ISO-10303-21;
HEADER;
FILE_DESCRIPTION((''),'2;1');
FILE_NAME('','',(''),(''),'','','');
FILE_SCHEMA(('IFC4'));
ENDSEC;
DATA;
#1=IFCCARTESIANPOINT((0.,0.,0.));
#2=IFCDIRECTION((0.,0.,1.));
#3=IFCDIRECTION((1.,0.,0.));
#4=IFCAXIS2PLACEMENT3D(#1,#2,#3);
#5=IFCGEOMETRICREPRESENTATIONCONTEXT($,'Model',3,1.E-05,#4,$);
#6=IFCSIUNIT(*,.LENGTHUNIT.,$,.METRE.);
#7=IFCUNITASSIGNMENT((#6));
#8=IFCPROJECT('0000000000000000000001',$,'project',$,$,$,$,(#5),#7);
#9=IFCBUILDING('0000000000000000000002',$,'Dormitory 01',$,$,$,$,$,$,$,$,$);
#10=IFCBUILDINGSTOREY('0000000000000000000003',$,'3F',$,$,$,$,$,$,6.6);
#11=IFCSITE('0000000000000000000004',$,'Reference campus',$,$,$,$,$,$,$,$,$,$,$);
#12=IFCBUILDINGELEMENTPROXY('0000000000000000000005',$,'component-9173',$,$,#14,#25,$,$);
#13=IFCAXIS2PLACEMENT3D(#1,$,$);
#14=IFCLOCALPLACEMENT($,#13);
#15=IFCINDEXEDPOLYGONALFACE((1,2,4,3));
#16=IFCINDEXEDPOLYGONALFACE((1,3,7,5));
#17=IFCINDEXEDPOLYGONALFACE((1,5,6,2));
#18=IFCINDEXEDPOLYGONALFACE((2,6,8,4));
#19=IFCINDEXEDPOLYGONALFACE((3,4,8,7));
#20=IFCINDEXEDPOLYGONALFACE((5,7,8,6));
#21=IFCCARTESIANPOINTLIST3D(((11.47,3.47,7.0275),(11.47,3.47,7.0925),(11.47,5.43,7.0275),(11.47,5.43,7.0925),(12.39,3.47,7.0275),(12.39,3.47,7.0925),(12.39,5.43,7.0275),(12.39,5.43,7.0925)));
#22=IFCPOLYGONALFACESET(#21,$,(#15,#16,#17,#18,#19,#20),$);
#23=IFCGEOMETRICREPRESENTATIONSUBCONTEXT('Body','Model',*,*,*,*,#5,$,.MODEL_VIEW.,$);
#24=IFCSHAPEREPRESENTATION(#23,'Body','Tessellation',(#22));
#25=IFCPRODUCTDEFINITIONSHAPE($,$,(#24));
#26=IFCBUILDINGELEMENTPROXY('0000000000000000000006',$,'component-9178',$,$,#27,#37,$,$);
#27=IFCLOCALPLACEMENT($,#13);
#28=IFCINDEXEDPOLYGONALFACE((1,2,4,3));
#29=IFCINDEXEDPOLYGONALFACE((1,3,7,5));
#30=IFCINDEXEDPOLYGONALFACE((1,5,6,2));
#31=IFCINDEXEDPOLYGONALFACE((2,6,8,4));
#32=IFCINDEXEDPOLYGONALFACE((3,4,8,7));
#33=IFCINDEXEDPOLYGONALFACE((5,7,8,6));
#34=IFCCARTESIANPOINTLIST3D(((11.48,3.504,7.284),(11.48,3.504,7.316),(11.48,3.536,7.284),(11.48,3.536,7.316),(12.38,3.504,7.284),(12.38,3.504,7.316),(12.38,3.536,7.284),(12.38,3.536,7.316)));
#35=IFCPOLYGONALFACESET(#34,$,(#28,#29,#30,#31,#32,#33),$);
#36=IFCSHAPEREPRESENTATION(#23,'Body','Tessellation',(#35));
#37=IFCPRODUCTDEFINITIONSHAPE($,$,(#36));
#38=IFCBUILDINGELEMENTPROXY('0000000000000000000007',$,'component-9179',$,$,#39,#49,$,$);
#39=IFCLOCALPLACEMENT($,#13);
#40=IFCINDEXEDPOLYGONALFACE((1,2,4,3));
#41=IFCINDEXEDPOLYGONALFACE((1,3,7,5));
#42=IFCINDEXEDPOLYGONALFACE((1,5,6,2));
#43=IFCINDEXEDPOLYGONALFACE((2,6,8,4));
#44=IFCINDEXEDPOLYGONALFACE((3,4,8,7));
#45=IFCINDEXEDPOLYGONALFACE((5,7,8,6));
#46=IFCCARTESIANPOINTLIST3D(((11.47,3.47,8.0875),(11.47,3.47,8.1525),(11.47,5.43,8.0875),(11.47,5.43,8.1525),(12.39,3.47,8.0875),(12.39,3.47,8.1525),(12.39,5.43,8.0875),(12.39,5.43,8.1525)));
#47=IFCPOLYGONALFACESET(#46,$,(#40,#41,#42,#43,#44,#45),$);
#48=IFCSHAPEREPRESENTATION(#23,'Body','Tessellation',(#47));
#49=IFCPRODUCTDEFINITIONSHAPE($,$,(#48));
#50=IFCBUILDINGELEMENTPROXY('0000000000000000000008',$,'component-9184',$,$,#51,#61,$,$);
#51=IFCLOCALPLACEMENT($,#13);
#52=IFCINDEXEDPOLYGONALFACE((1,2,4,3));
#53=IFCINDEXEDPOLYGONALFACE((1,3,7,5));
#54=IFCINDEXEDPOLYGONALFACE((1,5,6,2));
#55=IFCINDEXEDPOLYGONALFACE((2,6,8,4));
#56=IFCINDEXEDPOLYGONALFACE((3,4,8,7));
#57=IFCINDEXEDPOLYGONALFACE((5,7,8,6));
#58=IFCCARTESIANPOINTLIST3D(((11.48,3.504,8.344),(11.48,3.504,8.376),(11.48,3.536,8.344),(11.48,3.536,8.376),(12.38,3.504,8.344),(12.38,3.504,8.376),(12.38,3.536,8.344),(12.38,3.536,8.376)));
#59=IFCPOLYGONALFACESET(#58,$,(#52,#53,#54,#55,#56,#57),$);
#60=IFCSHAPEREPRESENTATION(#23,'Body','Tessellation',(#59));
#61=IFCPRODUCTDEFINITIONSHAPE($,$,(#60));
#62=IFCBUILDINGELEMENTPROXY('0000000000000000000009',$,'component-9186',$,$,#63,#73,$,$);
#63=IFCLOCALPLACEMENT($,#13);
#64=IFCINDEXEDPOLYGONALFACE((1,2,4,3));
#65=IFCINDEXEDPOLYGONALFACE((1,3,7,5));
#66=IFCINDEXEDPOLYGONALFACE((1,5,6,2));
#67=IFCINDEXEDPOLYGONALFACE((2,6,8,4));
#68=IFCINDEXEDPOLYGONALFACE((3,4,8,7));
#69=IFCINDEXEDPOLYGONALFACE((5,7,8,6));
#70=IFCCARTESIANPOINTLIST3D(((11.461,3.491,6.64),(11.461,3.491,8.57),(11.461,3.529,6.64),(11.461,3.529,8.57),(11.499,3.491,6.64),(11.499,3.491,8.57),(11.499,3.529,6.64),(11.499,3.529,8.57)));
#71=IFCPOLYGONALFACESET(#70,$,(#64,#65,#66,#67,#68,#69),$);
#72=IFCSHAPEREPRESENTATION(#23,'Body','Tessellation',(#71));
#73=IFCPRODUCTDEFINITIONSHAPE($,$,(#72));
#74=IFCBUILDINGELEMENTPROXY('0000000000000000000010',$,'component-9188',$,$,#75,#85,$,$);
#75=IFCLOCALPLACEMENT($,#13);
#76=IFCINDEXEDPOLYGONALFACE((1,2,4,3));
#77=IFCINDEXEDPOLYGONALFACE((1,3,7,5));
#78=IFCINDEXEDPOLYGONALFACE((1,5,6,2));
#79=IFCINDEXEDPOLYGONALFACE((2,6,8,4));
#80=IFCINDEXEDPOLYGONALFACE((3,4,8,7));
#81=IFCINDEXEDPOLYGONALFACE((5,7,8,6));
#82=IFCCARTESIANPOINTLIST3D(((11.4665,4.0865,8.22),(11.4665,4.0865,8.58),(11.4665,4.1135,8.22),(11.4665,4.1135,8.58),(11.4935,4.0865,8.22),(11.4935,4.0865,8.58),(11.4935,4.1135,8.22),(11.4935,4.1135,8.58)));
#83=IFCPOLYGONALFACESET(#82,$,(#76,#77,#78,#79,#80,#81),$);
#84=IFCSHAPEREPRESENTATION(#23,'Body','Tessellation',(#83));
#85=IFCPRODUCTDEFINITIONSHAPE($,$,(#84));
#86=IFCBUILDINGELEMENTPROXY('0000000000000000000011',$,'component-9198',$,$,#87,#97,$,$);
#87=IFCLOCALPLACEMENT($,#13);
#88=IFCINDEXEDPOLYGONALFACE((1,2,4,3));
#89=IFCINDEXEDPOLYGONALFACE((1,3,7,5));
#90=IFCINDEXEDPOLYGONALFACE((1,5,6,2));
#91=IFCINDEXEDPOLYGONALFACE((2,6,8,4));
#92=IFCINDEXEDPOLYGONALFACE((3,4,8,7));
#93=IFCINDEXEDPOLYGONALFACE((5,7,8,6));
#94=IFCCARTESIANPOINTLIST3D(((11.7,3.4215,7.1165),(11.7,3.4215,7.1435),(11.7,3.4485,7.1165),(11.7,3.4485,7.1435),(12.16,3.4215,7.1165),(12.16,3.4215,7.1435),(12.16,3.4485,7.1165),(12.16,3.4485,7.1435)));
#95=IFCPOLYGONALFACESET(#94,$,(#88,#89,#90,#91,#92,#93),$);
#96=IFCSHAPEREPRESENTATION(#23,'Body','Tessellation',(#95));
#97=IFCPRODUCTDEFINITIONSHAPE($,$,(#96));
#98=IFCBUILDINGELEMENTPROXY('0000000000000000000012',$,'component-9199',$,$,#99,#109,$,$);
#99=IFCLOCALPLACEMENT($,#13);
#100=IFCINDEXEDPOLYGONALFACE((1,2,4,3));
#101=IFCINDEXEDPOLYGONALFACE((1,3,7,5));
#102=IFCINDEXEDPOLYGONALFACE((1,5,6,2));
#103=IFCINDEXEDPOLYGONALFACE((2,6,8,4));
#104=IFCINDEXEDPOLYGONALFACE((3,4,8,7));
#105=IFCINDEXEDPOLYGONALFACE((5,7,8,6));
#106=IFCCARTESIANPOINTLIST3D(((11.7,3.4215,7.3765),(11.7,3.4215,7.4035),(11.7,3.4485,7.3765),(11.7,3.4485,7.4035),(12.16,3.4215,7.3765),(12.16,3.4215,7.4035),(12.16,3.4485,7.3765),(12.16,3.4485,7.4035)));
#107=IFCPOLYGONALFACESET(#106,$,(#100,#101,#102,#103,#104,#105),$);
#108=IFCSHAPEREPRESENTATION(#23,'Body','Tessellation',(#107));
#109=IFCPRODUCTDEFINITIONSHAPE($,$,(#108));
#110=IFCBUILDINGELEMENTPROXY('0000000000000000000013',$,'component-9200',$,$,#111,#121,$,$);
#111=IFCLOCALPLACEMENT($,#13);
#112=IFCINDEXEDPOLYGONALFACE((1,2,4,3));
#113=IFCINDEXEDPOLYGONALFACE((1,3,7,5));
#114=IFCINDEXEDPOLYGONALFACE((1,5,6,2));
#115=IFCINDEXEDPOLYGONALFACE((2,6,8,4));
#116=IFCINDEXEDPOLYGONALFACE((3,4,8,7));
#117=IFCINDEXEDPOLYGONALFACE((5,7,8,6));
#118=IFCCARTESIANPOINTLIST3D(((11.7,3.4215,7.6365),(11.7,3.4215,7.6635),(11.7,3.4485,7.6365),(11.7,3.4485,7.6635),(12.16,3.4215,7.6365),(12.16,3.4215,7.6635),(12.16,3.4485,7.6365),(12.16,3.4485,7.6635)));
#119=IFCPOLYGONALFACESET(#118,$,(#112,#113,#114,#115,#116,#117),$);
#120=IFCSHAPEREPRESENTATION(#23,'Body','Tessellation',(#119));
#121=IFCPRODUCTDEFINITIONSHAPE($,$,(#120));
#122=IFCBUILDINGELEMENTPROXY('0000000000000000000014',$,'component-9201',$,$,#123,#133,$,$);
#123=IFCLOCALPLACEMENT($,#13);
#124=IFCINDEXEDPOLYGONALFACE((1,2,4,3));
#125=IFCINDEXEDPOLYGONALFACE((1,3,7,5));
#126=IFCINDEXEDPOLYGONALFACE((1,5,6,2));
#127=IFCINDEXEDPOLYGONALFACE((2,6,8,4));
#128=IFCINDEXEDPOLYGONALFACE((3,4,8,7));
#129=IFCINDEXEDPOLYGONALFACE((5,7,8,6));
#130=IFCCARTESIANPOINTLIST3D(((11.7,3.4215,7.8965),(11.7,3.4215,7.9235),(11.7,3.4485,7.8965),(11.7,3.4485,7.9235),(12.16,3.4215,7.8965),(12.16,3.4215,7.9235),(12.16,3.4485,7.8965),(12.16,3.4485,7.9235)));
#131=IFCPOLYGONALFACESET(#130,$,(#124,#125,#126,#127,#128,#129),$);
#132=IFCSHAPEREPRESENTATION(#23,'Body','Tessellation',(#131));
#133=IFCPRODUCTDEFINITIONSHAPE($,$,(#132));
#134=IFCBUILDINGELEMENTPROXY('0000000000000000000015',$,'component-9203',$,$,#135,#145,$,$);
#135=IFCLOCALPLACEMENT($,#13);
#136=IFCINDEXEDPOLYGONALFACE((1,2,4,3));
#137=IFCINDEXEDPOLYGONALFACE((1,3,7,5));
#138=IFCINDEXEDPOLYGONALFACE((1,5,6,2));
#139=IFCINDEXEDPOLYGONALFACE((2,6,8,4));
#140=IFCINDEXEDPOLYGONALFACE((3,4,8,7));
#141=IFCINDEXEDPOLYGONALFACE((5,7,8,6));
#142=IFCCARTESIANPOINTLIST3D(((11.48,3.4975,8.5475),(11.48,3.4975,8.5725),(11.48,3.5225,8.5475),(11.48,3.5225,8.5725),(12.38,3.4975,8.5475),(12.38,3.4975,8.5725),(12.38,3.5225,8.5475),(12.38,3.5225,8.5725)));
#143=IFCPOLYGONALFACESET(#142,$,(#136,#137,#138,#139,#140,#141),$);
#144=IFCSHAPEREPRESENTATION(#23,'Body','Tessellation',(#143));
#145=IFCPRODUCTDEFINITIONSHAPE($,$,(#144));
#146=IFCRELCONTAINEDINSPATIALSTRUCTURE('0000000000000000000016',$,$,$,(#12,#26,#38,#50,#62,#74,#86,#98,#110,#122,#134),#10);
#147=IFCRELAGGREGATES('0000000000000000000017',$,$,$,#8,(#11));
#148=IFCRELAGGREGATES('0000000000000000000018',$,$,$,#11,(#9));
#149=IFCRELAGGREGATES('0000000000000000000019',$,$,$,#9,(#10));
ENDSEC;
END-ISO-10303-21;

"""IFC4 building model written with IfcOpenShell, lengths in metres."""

from ifc_helpers import new_model, si_unit, frame, origin, origin_with_axes, origin_2d, place, context, subcontext, project, spatial, rectangle, extrude, element, save


model = new_model("IFC4")

# Units and contexts
model_context = context("Model", 3, precision=1e-05, world=origin_with_axes())
body_context = subcontext(model_context, "Body", "Model", "MODEL_VIEW")
ifc_project = project(units=[si_unit("LENGTHUNIT", "METRE")], contexts=[model_context])

# Site, building, storey
site = spatial("IfcSite", under=ifc_project, Name="Reference campus")
building = spatial("IfcBuilding", under=site, Name="Dormitory 01")
storey = spatial("IfcBuildingStorey", under=building, Name="3F", Elevation=6.6)

# Building element proxies
proxy_1_placement = place(None, frame((11.93, 4.45, 7.0275), z_axis=(0.0, 0.0, 1.0), x_axis=(1.0, 0.0, 0.0)))
element("IfcBuildingElementProxy", 1, at=proxy_1_placement, inside=storey, Name="component-9173", context=body_context, shape_type="SweptSolid", body=[
    extrude(rectangle(XDim=0.92, YDim=1.96, at=origin_2d()), origin(), (0.0, 0.0, 1.0), 0.065),
])
proxy_2_placement = place(None, frame((11.93, 3.52, 7.284), z_axis=(0.0, 0.0, 1.0), x_axis=(1.0, 0.0, 0.0)))
element("IfcBuildingElementProxy", 2, at=proxy_2_placement, inside=storey, Name="component-9178", context=body_context, shape_type="SweptSolid", body=[
    extrude(rectangle(XDim=0.9, YDim=0.032, at=origin_2d()), origin(), (0.0, 0.0, 1.0), 0.032),
])
proxy_3_placement = place(None, frame((11.93, 4.45, 8.0875), z_axis=(0.0, 0.0, 1.0), x_axis=(1.0, 0.0, 0.0)))
element("IfcBuildingElementProxy", 3, at=proxy_3_placement, inside=storey, Name="component-9179", context=body_context, shape_type="SweptSolid", body=[
    extrude(rectangle(XDim=0.92, YDim=1.96, at=origin_2d()), origin(), (0.0, 0.0, 1.0), 0.065),
])
proxy_4_placement = place(None, frame((11.93, 3.52, 8.344), z_axis=(0.0, 0.0, 1.0), x_axis=(1.0, 0.0, 0.0)))
element("IfcBuildingElementProxy", 4, at=proxy_4_placement, inside=storey, Name="component-9184", context=body_context, shape_type="SweptSolid", body=[
    extrude(rectangle(XDim=0.9, YDim=0.032, at=origin_2d()), origin(), (0.0, 0.0, 1.0), 0.032),
])
proxy_5_placement = place(None, frame((11.48, 3.51, 6.64), z_axis=(0.0, 0.0, 1.0), x_axis=(1.0, 0.0, 0.0)))
element("IfcBuildingElementProxy", 5, at=proxy_5_placement, inside=storey, Name="component-9186", context=body_context, shape_type="SweptSolid", body=[
    extrude(rectangle(XDim=0.038, YDim=0.038, at=origin_2d()), origin(), (0.0, 0.0, 1.0), 1.93),
])
proxy_6_placement = place(None, frame((11.48, 4.1, 8.22), z_axis=(0.0, 0.0, 1.0), x_axis=(1.0, 0.0, 0.0)))
element("IfcBuildingElementProxy", 6, at=proxy_6_placement, inside=storey, Name="component-9188", context=body_context, shape_type="SweptSolid", body=[
    extrude(rectangle(XDim=0.027, YDim=0.027, at=origin_2d()), origin(), (0.0, 0.0, 1.0), 0.36),
])
for number, where, z_axis, x_axis, name in (
    (7, (11.93, 3.435, 7.1165), (0.0, 0.0, 1.0), (1.0, 0.0, 0.0), "component-9198"),
    (8, (11.93, 3.435, 7.3765), (0.0, 0.0, 1.0), (1.0, 0.0, 0.0), "component-9199"),
    (9, (11.93, 3.435, 7.6365), (0.0, 0.0, 1.0), (1.0, 0.0, 0.0), "component-9200"),
    (10, (11.93, 3.435, 7.8965), (0.0, 0.0, 1.0), (1.0, 0.0, 0.0), "component-9201"),
):
    element("IfcBuildingElementProxy", number, at=place(None, frame(where, z_axis=z_axis, x_axis=x_axis)), inside=storey, Name=name, context=body_context, shape_type="SweptSolid", body=[
        extrude(rectangle(XDim=0.46, YDim=0.027, at=origin_2d()), origin(), (0.0, 0.0, 1.0), 0.027),
    ])
proxy_7_placement = place(None, frame((11.93, 3.51, 8.5475), z_axis=(0.0, 0.0, 1.0), x_axis=(1.0, 0.0, 0.0)))
element("IfcBuildingElementProxy", 11, at=proxy_7_placement, inside=storey, Name="component-9203", context=body_context, shape_type="SweptSolid", body=[
    extrude(rectangle(XDim=0.9, YDim=0.025, at=origin_2d()), origin(), (0.0, 0.0, 1.0), 0.025),
])

save(model, "model.ifc")
